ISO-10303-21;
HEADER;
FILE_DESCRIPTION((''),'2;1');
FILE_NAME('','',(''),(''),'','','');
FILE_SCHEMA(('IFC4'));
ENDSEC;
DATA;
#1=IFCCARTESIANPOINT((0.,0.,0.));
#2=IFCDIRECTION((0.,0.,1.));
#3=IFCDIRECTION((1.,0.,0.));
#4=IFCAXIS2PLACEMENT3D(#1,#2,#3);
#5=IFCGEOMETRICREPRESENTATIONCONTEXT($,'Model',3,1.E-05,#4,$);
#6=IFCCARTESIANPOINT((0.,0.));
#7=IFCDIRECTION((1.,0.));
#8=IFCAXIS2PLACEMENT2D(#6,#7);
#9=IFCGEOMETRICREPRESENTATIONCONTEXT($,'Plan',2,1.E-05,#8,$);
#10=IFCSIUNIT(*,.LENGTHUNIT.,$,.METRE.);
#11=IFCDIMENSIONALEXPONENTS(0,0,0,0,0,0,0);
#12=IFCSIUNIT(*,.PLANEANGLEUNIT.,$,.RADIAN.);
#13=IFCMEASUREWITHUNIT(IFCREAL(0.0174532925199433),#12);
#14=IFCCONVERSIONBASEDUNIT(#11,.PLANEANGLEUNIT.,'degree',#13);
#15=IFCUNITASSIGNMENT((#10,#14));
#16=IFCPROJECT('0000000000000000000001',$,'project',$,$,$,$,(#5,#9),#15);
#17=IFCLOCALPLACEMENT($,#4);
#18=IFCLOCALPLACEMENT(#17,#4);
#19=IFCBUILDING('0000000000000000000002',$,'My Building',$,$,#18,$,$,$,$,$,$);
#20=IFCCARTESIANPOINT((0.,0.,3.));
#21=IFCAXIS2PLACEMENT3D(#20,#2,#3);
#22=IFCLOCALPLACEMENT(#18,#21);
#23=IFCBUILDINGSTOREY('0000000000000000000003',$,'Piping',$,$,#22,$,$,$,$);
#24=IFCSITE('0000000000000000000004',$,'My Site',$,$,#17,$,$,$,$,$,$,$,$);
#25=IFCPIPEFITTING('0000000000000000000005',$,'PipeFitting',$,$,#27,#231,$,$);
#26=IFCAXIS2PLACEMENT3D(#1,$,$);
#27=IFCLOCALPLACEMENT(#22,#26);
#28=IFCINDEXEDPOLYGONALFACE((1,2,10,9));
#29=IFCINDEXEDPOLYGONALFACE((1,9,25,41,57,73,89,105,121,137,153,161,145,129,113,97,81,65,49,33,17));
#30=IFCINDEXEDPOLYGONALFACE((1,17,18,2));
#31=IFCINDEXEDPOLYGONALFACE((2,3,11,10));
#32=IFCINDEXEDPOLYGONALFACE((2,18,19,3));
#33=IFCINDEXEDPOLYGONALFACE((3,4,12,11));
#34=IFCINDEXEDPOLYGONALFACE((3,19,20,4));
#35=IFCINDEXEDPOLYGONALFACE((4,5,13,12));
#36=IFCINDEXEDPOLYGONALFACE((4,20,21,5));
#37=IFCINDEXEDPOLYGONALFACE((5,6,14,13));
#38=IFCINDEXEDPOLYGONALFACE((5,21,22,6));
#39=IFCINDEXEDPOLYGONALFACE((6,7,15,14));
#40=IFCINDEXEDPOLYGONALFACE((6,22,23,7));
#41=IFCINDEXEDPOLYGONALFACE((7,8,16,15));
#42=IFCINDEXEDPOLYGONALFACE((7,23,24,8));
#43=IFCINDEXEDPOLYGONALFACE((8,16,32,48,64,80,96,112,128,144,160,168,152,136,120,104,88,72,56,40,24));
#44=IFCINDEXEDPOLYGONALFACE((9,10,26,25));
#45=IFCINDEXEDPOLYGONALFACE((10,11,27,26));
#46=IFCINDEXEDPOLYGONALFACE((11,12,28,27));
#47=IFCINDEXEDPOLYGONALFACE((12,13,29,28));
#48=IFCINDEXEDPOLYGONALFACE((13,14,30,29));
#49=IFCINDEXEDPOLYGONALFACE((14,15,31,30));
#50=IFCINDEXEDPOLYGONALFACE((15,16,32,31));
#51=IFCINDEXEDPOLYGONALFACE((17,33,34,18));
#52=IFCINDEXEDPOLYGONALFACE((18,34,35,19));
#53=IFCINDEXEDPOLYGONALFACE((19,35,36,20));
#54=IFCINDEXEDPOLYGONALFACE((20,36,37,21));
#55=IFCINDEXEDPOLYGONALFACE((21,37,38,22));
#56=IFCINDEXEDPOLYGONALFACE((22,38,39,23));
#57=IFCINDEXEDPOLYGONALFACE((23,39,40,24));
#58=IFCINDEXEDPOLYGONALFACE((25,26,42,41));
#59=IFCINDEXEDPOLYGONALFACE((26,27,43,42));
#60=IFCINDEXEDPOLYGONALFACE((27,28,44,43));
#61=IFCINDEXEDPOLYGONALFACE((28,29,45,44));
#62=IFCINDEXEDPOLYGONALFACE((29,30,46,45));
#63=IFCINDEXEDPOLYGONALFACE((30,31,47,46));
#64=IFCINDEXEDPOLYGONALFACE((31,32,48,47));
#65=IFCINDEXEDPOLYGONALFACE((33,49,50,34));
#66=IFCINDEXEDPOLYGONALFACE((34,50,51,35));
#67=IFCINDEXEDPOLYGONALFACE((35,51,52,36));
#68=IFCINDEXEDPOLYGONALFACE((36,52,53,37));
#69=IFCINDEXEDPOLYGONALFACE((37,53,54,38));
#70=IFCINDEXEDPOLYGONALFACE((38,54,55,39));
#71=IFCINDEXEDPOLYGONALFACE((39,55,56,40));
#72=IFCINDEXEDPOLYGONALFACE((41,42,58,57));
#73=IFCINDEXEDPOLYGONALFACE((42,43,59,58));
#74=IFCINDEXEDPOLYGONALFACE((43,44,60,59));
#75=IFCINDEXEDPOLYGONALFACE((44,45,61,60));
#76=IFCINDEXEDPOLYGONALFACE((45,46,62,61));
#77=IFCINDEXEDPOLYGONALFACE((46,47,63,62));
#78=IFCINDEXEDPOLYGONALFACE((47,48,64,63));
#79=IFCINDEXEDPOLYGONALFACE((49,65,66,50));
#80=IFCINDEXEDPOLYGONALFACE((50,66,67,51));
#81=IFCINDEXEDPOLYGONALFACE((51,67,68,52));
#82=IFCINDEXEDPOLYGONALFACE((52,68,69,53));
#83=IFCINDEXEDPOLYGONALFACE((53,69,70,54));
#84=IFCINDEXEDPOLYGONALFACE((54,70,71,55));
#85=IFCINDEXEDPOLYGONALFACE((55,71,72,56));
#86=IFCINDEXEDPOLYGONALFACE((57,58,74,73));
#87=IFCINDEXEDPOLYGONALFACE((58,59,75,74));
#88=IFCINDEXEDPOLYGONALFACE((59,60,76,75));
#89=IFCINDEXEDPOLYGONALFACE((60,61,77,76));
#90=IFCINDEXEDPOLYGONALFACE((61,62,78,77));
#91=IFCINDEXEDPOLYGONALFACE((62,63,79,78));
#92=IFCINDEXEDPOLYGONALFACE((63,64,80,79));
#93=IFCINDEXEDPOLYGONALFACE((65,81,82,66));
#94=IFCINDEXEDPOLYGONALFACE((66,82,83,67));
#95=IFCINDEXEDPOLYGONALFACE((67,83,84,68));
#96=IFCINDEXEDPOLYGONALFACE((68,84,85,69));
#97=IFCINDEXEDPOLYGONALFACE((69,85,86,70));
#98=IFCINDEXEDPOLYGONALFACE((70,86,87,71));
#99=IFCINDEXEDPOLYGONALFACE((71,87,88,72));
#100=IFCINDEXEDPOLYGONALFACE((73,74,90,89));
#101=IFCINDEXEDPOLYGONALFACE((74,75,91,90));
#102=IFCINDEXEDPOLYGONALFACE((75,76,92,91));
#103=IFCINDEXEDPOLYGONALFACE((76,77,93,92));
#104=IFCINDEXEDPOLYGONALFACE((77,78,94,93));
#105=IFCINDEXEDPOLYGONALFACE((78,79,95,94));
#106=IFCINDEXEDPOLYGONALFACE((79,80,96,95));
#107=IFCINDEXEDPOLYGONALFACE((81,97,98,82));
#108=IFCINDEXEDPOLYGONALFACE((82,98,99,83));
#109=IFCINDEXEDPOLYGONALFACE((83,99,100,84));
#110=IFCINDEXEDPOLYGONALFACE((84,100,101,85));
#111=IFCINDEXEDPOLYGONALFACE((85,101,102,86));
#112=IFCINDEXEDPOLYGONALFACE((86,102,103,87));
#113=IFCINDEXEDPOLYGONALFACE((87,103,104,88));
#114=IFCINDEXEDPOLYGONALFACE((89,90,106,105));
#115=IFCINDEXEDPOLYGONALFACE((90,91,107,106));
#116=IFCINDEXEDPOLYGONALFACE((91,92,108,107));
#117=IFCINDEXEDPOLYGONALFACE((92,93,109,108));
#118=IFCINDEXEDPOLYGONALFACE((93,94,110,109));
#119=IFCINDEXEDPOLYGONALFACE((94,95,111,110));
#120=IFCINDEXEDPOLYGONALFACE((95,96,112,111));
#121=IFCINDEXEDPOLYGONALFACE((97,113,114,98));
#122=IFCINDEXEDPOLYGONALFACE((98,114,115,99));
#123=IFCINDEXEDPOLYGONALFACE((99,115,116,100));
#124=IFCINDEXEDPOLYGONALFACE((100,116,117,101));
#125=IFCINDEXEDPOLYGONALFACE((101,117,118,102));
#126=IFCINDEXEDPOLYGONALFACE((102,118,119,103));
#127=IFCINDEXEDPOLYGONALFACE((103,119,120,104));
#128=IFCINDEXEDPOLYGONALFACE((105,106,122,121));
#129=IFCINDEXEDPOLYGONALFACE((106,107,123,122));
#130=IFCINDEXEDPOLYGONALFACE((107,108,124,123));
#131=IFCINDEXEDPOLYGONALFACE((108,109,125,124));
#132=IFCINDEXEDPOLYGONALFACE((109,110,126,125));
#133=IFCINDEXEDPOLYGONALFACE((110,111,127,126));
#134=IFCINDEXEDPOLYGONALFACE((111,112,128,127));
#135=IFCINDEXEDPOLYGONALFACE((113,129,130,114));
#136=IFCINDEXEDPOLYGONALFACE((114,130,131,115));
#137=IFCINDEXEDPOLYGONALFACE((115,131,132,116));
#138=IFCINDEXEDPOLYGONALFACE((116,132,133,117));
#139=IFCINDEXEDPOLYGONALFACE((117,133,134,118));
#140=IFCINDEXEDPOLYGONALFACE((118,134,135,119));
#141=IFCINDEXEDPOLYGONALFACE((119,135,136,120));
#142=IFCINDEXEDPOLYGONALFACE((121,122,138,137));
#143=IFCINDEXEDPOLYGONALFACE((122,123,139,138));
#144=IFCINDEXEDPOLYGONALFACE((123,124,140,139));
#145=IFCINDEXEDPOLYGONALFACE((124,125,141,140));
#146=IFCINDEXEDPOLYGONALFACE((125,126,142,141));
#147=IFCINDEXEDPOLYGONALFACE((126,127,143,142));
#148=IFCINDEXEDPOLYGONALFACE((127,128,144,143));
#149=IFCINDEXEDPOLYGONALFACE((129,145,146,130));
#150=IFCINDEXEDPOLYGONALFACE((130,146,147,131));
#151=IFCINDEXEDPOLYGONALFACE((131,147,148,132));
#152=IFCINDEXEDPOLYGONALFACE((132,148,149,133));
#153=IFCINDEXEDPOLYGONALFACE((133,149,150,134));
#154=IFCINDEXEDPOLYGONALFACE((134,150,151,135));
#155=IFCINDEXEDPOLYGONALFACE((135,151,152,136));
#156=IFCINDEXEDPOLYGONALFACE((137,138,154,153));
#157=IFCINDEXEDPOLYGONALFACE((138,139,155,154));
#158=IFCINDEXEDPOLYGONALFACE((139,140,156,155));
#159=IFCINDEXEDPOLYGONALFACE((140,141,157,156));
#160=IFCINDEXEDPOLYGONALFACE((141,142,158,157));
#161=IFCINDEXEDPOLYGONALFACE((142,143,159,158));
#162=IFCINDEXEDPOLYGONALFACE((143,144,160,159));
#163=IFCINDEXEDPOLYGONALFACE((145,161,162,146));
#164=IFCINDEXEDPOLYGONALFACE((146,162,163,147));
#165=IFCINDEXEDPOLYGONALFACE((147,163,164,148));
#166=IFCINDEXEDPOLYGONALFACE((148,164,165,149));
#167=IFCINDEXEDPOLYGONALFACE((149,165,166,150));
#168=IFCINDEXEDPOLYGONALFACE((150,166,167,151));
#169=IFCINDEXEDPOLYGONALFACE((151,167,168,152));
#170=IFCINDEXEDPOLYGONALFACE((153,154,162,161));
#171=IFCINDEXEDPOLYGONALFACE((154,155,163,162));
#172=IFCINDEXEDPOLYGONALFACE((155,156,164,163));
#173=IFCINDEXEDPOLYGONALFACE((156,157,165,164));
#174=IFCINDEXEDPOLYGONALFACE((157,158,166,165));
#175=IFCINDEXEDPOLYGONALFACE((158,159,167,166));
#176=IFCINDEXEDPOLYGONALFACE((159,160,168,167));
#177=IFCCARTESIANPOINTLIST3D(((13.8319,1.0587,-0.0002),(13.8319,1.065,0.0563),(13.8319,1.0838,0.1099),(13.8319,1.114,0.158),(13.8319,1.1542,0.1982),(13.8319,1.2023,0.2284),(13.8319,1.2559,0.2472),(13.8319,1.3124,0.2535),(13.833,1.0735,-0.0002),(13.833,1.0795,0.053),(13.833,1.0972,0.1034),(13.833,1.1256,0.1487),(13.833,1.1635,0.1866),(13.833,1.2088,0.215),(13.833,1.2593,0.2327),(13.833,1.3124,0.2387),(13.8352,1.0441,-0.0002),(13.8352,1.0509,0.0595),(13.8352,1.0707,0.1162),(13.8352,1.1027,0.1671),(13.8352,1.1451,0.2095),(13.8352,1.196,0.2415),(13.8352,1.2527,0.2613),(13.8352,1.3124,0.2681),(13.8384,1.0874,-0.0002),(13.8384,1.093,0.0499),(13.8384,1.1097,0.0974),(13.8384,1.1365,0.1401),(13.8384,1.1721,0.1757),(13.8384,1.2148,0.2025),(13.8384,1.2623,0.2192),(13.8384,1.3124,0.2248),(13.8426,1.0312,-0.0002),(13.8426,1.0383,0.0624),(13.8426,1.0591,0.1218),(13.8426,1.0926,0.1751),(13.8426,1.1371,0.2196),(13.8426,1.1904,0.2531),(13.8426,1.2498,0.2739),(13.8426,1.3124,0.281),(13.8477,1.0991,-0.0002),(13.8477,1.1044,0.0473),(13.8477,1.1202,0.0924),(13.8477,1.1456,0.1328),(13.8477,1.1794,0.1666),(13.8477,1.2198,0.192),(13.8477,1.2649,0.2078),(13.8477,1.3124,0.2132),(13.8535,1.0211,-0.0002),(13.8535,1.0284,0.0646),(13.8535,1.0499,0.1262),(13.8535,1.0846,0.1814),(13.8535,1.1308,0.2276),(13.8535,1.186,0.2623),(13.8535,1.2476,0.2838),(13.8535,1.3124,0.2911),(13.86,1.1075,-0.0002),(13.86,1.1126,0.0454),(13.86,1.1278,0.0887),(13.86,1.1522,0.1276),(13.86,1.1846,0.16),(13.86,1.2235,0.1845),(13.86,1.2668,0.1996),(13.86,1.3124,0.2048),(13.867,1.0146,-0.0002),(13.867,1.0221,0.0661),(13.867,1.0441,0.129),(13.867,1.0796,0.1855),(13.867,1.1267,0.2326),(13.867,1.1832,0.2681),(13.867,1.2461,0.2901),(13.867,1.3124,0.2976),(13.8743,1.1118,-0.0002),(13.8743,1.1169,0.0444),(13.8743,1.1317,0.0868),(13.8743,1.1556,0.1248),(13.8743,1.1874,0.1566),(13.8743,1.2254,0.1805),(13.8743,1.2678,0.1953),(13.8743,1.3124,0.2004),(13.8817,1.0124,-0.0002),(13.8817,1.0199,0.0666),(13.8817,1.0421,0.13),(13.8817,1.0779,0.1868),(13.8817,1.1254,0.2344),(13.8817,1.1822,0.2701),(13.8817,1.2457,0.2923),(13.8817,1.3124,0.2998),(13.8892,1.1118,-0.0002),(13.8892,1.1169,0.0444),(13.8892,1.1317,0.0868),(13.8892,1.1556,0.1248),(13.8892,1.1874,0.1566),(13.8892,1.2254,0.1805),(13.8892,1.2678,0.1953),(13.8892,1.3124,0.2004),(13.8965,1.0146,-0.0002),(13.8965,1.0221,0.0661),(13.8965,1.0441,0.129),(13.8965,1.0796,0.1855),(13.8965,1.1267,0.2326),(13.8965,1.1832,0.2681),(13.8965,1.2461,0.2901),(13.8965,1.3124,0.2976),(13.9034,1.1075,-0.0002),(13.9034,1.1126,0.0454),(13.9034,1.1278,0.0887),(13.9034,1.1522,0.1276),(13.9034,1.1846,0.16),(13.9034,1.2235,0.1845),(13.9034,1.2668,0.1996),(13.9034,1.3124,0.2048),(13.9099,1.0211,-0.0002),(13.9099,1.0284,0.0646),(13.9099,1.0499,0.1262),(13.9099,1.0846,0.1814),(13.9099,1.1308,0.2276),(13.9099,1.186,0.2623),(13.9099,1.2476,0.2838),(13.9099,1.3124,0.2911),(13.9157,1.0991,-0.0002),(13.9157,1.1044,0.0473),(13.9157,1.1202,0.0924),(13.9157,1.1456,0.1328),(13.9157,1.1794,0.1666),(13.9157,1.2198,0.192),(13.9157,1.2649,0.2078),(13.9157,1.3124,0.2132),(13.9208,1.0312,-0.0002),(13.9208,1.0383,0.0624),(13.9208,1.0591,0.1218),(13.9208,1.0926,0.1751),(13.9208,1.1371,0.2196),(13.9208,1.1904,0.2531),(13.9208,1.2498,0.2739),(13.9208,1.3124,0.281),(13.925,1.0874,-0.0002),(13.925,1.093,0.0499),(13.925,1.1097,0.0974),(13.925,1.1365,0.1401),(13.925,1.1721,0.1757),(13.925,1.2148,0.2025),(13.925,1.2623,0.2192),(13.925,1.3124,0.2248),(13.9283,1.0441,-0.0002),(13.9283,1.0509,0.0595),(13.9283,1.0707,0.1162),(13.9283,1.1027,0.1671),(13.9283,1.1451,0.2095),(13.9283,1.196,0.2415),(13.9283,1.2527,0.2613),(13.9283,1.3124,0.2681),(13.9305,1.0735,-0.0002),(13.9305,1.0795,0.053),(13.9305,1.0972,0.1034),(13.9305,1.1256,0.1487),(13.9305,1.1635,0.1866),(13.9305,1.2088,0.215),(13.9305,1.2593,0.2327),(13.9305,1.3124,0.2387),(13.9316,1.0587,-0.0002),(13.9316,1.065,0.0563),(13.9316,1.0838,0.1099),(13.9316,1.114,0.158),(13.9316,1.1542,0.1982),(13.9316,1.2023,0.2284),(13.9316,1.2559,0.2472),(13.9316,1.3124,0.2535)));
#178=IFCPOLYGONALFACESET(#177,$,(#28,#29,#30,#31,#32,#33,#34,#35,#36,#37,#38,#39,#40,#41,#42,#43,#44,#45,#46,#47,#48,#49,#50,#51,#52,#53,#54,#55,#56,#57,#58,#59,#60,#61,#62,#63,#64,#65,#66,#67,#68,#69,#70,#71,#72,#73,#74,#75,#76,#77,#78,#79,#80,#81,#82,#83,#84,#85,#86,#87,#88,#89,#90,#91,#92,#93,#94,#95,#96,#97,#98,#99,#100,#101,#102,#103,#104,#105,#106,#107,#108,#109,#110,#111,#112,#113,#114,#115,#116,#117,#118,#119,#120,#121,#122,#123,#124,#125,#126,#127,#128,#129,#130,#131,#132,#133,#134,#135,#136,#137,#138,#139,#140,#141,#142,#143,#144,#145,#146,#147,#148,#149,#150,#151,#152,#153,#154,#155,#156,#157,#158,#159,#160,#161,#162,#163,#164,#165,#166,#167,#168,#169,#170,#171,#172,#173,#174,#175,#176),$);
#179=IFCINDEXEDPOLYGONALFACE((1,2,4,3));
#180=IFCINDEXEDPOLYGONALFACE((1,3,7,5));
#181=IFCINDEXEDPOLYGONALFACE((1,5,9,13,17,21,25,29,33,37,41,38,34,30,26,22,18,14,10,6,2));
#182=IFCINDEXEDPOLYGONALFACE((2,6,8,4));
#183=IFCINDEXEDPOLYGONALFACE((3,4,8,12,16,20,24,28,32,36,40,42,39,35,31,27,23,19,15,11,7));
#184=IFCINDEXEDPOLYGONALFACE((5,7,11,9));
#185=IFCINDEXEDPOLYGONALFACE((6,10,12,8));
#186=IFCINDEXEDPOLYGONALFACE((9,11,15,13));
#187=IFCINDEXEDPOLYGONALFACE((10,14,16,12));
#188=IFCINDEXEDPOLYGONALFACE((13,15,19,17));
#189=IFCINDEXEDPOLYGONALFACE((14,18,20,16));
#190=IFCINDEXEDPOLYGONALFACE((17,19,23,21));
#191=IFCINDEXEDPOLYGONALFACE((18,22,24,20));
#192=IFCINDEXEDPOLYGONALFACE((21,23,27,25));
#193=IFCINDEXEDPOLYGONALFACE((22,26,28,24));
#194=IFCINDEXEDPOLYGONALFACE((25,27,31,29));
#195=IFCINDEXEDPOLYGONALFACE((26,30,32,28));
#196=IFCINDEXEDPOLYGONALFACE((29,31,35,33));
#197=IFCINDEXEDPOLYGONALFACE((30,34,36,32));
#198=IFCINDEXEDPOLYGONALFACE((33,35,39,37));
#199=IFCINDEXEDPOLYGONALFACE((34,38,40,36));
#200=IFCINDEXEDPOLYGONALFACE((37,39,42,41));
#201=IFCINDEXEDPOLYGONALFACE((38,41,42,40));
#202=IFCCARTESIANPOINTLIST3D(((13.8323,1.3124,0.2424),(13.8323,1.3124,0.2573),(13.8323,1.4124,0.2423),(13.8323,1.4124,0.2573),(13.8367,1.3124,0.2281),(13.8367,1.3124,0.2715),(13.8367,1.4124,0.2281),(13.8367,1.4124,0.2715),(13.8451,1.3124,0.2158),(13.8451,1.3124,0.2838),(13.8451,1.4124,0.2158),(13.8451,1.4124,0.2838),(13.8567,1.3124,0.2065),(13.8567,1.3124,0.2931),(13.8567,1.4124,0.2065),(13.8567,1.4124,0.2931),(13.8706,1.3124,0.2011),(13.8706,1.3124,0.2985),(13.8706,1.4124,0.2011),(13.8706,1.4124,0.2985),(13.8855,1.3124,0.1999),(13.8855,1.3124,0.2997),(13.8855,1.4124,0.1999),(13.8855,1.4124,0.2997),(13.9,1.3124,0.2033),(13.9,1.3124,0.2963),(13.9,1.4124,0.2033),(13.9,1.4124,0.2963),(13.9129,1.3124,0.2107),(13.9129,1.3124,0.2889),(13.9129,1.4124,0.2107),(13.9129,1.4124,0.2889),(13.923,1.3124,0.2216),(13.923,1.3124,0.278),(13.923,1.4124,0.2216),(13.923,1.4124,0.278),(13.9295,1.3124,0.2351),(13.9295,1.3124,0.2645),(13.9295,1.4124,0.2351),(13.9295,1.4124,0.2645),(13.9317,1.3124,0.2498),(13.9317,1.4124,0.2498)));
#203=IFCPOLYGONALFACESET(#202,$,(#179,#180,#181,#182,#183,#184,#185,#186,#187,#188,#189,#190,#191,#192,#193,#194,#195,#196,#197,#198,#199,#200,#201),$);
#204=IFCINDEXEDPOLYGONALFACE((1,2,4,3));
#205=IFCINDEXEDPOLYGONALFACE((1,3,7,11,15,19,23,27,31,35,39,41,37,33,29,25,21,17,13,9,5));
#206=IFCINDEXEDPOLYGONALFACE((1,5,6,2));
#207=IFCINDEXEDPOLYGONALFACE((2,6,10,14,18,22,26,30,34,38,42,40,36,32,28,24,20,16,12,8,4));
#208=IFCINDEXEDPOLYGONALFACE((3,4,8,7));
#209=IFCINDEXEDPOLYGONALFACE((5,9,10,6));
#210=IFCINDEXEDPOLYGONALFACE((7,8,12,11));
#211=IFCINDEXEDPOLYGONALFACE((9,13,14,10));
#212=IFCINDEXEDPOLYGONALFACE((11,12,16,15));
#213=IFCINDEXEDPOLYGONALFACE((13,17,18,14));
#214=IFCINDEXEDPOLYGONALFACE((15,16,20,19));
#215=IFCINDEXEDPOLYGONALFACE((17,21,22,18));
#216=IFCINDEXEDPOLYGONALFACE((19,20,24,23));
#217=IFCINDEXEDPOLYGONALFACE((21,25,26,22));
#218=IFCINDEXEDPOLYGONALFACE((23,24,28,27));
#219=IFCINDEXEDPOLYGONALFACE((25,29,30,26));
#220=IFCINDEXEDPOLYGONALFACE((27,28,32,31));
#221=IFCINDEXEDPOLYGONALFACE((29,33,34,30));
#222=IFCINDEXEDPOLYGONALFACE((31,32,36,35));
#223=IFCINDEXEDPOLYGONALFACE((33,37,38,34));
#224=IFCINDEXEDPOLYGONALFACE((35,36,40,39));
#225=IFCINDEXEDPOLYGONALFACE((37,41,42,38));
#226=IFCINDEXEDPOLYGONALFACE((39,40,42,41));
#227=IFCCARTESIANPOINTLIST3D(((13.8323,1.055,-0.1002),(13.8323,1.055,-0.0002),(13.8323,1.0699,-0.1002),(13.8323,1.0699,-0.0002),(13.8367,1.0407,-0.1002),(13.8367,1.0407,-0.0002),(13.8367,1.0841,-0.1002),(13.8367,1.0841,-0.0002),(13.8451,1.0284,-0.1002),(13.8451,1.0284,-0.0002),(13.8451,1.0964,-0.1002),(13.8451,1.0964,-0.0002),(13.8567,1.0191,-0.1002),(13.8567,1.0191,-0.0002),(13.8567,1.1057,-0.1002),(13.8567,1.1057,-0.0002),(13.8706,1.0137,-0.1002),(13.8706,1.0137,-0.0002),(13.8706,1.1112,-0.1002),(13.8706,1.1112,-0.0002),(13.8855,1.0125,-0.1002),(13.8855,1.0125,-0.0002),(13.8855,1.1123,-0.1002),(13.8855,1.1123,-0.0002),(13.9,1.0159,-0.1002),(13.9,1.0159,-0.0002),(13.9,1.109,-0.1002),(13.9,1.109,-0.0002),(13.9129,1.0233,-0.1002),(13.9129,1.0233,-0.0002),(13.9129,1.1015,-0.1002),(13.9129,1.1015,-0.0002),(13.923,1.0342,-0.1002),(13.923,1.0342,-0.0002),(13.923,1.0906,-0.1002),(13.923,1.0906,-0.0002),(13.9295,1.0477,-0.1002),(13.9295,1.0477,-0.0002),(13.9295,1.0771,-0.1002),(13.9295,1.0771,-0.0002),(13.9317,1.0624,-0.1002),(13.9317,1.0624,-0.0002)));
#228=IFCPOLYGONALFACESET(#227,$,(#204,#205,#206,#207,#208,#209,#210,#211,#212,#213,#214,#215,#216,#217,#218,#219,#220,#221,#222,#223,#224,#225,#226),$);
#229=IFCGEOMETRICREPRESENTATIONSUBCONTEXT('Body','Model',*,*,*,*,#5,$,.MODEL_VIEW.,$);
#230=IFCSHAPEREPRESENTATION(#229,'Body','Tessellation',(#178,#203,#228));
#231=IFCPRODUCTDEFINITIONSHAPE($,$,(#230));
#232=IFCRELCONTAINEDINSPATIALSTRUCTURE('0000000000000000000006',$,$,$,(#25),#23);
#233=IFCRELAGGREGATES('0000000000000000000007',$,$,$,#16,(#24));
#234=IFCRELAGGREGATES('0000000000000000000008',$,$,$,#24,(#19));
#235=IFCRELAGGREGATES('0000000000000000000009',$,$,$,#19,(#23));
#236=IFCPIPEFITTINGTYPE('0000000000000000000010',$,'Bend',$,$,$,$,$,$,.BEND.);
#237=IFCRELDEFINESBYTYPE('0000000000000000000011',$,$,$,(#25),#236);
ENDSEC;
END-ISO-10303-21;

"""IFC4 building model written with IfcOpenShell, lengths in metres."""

from ifc_helpers import new_model, entity, si_unit, converted_unit, frame, origin_with_axes, origin_2d_with_axis, place, context, subcontext, project, spatial, circle, extrude, source, transform, mapped, type_object, type_shapes, element, save


model = new_model("IFC4")

# Units and contexts
model_context = context("Model", 3, precision=1e-05, world=origin_with_axes())
plan_context = context("Plan", 2, precision=1e-05, world=origin_2d_with_axis())
body_context = subcontext(model_context, "Body", "Model", "MODEL_VIEW")
ifc_project = project(units=[si_unit("LENGTHUNIT", "METRE"), converted_unit("PLANEANGLEUNIT", "degree", entity("IfcReal", 0.0174532925199433), si_unit("PLANEANGLEUNIT", "RADIAN"), dimensions=[0, 0, 0, 0, 0, 0, 0])], contexts=[model_context, plan_context])

# Site, building, storey
site_placement = place(None, origin_with_axes())
site = spatial("IfcSite", under=ifc_project, at=site_placement, Name="My Site")
building_placement = place(site_placement, origin_with_axes())
building = spatial("IfcBuilding", under=site, at=building_placement, Name="My Building")
storey_placement = place(building_placement, frame((0.0, 0.0, 3.0), z_axis=(0.0, 0.0, 1.0), x_axis=(1.0, 0.0, 0.0)))
storey = spatial("IfcBuildingStorey", under=building, at=storey_placement, Name="Piping")

# Pipe fitting
pipe_fitting_type_1 = type_object("IfcPipeFittingType", Name="Bend", PredefinedType="BEND")
shared_shape = source(origin_with_axes(), body_context, "Body", "SolidModel", [
    entity("IfcSweptDiskSolid", entity("IfcIndexedPolyCurve", entity("IfcCartesianPointList3D", [[0.0, 0.0, 0.1], [0.0, -0.0732, 0.2768], [0.0, -0.25, 0.35]]), [entity("IfcArcIndex", [1, 2, 3])]), 0.05),
    extrude(circle(Radius=0.05), origin_with_axes(), (0.0, 0.0, 1.0), 0.1),
    extrude(circle(Radius=0.05), frame((0.0, -0.25, 0.35), z_axis=(0.0, -1.0, -0.00003), x_axis=(1.0, 0.0, 0.0)), (0.0, 0.0, 1.0), 0.1),
])
type_shapes(pipe_fitting_type_1, [shared_shape])
for number, where, z_axis, x_axis, name in (
    (1, (13.8817, 1.4124, 0.2498), (0.0, -1.0, 0.000008), (1.0, 0.0, 0.0), "PipeFitting"),
):
    element("IfcPipeFitting", number, at=place(storey_placement, frame(where, z_axis=z_axis, x_axis=x_axis)), inside=storey, type_object=pipe_fitting_type_1, Name=name, context=body_context, shape_type="MappedRepresentation", body=[
        mapped(shared_shape, transform((0.0, 0.0, 0.0), x_axis=(1.0, 0.0, 0.0), y_axis=(0.0, 1.0, 0.0), z_axis=(0.0, 0.0, 1.0), scale=1.0)),
    ])

save(model, "model.ifc")
